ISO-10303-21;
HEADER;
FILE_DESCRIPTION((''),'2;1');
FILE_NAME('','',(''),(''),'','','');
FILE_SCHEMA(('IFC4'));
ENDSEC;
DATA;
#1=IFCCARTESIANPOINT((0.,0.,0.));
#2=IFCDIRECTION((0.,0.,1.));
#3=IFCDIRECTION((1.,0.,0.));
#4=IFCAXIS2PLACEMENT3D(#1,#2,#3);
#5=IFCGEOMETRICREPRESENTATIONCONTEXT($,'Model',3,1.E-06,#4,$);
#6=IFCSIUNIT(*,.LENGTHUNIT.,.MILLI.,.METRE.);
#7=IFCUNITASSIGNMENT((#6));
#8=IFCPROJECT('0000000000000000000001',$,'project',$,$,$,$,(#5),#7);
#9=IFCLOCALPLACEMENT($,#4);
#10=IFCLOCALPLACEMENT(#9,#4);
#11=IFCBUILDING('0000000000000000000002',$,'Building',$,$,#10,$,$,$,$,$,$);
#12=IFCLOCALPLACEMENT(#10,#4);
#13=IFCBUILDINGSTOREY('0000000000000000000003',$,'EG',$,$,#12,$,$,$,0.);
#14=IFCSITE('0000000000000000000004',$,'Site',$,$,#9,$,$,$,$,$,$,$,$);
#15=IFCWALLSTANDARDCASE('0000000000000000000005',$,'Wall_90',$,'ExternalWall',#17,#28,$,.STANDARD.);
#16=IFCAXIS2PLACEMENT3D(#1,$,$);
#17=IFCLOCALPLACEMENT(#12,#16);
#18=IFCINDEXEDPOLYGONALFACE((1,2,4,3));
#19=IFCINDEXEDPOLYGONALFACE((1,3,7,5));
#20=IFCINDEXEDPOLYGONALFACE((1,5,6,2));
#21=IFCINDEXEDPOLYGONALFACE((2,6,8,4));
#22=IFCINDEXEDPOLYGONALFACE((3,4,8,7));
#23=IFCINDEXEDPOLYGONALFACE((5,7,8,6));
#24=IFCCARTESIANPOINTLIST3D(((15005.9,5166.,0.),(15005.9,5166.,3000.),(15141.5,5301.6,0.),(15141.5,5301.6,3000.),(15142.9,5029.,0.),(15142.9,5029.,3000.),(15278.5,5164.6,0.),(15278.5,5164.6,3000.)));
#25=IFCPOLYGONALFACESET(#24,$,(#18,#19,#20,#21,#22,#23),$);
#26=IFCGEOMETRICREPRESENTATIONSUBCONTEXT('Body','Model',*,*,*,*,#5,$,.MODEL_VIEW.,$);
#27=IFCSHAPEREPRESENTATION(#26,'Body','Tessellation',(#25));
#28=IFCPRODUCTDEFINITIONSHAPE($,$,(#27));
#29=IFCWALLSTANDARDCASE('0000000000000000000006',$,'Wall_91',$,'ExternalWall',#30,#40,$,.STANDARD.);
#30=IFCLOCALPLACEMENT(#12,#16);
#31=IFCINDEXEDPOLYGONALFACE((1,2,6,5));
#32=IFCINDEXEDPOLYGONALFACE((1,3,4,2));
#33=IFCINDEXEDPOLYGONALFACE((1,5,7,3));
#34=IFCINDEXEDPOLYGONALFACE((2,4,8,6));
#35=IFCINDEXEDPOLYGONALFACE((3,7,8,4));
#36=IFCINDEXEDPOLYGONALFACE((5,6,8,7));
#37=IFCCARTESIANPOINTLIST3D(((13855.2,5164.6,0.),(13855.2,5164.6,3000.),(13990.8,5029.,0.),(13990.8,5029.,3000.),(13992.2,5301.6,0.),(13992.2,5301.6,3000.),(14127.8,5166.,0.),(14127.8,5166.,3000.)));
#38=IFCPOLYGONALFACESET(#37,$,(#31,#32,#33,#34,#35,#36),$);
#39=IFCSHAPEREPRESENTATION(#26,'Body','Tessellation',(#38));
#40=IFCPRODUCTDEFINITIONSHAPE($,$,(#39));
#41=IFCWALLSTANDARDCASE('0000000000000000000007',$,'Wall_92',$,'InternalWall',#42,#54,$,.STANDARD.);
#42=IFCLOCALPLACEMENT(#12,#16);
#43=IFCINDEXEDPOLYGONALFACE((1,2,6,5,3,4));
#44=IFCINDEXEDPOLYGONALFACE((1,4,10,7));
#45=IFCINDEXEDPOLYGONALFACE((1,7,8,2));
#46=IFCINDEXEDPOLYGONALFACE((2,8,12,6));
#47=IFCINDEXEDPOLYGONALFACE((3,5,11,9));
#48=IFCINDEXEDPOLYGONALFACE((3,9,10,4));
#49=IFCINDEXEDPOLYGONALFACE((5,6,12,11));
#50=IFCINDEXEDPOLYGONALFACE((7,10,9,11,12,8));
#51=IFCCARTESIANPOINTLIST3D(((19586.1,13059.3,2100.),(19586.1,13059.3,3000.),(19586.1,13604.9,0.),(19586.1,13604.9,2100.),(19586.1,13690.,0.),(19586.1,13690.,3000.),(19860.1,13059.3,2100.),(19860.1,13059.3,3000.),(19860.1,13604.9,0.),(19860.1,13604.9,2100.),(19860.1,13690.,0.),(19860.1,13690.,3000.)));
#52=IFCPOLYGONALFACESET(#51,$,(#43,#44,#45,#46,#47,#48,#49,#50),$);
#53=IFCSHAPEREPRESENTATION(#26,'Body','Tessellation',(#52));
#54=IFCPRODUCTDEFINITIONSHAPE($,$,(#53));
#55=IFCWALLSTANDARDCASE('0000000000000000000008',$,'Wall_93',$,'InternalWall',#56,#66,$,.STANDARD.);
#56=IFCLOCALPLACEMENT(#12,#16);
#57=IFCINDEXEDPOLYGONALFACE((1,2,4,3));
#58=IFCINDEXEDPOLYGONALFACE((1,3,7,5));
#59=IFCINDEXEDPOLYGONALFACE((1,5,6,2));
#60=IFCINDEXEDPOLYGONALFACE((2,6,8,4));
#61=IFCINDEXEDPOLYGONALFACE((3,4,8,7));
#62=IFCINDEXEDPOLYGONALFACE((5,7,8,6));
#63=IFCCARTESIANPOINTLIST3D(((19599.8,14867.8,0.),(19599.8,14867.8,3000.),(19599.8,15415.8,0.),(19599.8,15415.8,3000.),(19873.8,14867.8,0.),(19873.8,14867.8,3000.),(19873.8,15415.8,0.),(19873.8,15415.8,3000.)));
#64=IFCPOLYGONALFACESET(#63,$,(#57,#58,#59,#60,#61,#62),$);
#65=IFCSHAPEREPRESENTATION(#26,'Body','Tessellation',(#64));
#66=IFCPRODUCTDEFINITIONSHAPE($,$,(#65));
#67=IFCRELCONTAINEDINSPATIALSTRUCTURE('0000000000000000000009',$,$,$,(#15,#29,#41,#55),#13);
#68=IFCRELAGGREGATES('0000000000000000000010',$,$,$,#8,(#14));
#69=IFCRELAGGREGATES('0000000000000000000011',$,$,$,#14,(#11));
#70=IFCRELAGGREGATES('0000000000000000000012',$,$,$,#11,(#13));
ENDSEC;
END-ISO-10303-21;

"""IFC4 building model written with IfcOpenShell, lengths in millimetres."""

from ifc_helpers import new_model, si_unit, frame, origin_with_axes, place, context, subcontext, project, spatial, rectangle, extrude, element, save


model = new_model("IFC4")

# Units and contexts
model_context = context("Model", 3, precision=1e-06, world=origin_with_axes())
body_context = subcontext(model_context, "Body", "Model", "MODEL_VIEW")
ifc_project = project(units=[si_unit("LENGTHUNIT", "METRE", prefix="MILLI")], contexts=[model_context])

# Site, building, storey
site_placement = place(None, origin_with_axes())
site = spatial("IfcSite", under=ifc_project, at=site_placement, Name="Site")
building_placement = place(site_placement, origin_with_axes())
building = spatial("IfcBuilding", under=site, at=building_placement, Name="Building")
storey_placement = place(building_placement, origin_with_axes())
storey = spatial("IfcBuildingStorey", under=building, at=storey_placement, Name="EG", Elevation=0.0)

# Walls
wall_1_placement = place(storey_placement, origin_with_axes())
element("IfcWallStandardCase", 1, at=wall_1_placement, inside=storey, Name="Wall_90", ObjectType="ExternalWall", PredefinedType="STANDARD", context=body_context, shape_type="SweptSolid", body=[
    extrude(rectangle(XDim=193.7, YDim=191.8), frame((15142.2, 5165.3, 0.0), z_axis=(0.0, 0.0, 1.0), x_axis=(0.707107, -0.707107, 0.0)), (0.0, 0.0, 1.0), 3000.0),
])
wall_2_placement = place(storey_placement, origin_with_axes())
element("IfcWallStandardCase", 2, at=wall_2_placement, inside=storey, Name="Wall_91", ObjectType="ExternalWall", PredefinedType="STANDARD", context=body_context, shape_type="SweptSolid", body=[
    extrude(rectangle(XDim=193.7, YDim=191.8), frame((13991.5, 5165.3, 0.0), z_axis=(0.0, 0.0, 1.0), x_axis=(-0.707107, -0.707107, 0.0)), (0.0, 0.0, 1.0), 3000.0),
])

# Wall, opening
wall_3_placement = place(storey_placement, origin_with_axes())
wall_3 = element("IfcWallStandardCase", 3, at=wall_3_placement, inside=storey, Name="Wall_92", ObjectType="InternalWall", PredefinedType="STANDARD", context=body_context, shape_type="SweptSolid", body=[
    extrude(rectangle(XDim=630.7, YDim=274.0), frame((19723.1, 13374.7, 0.0), z_axis=(0.0, 0.0, 1.0), x_axis=(0.0, -1.0, 0.0)), (0.0, 0.0, 1.0), 3000.0),
])
opening_1_placement = place(wall_3_placement, origin_with_axes())
element("IfcOpeningElement", 4, at=opening_1_placement, inside=storey, cuts=wall_3, context=body_context, shape_type="SweptSolid", body=[
    extrude(rectangle(XDim=545.6, YDim=274.0), frame((19723.1, 13332.1, 0.0), z_axis=(0.0, 0.0, 1.0), x_axis=(0.0, -1.0, 0.0)), (0.0, 0.0, 1.0), 2100.0),
])

# Wall
wall_4_placement = place(storey_placement, origin_with_axes())
element("IfcWallStandardCase", 5, at=wall_4_placement, inside=storey, Name="Wall_93", ObjectType="InternalWall", PredefinedType="STANDARD", context=body_context, shape_type="SweptSolid", body=[
    extrude(rectangle(XDim=547.9, YDim=274.0), frame((19736.8, 15141.8, 0.0), z_axis=(0.0, 0.0, 1.0), x_axis=(0.0, 1.0, 0.0)), (0.0, 0.0, 1.0), 3000.0),
])

save(model, "model.ifc")
